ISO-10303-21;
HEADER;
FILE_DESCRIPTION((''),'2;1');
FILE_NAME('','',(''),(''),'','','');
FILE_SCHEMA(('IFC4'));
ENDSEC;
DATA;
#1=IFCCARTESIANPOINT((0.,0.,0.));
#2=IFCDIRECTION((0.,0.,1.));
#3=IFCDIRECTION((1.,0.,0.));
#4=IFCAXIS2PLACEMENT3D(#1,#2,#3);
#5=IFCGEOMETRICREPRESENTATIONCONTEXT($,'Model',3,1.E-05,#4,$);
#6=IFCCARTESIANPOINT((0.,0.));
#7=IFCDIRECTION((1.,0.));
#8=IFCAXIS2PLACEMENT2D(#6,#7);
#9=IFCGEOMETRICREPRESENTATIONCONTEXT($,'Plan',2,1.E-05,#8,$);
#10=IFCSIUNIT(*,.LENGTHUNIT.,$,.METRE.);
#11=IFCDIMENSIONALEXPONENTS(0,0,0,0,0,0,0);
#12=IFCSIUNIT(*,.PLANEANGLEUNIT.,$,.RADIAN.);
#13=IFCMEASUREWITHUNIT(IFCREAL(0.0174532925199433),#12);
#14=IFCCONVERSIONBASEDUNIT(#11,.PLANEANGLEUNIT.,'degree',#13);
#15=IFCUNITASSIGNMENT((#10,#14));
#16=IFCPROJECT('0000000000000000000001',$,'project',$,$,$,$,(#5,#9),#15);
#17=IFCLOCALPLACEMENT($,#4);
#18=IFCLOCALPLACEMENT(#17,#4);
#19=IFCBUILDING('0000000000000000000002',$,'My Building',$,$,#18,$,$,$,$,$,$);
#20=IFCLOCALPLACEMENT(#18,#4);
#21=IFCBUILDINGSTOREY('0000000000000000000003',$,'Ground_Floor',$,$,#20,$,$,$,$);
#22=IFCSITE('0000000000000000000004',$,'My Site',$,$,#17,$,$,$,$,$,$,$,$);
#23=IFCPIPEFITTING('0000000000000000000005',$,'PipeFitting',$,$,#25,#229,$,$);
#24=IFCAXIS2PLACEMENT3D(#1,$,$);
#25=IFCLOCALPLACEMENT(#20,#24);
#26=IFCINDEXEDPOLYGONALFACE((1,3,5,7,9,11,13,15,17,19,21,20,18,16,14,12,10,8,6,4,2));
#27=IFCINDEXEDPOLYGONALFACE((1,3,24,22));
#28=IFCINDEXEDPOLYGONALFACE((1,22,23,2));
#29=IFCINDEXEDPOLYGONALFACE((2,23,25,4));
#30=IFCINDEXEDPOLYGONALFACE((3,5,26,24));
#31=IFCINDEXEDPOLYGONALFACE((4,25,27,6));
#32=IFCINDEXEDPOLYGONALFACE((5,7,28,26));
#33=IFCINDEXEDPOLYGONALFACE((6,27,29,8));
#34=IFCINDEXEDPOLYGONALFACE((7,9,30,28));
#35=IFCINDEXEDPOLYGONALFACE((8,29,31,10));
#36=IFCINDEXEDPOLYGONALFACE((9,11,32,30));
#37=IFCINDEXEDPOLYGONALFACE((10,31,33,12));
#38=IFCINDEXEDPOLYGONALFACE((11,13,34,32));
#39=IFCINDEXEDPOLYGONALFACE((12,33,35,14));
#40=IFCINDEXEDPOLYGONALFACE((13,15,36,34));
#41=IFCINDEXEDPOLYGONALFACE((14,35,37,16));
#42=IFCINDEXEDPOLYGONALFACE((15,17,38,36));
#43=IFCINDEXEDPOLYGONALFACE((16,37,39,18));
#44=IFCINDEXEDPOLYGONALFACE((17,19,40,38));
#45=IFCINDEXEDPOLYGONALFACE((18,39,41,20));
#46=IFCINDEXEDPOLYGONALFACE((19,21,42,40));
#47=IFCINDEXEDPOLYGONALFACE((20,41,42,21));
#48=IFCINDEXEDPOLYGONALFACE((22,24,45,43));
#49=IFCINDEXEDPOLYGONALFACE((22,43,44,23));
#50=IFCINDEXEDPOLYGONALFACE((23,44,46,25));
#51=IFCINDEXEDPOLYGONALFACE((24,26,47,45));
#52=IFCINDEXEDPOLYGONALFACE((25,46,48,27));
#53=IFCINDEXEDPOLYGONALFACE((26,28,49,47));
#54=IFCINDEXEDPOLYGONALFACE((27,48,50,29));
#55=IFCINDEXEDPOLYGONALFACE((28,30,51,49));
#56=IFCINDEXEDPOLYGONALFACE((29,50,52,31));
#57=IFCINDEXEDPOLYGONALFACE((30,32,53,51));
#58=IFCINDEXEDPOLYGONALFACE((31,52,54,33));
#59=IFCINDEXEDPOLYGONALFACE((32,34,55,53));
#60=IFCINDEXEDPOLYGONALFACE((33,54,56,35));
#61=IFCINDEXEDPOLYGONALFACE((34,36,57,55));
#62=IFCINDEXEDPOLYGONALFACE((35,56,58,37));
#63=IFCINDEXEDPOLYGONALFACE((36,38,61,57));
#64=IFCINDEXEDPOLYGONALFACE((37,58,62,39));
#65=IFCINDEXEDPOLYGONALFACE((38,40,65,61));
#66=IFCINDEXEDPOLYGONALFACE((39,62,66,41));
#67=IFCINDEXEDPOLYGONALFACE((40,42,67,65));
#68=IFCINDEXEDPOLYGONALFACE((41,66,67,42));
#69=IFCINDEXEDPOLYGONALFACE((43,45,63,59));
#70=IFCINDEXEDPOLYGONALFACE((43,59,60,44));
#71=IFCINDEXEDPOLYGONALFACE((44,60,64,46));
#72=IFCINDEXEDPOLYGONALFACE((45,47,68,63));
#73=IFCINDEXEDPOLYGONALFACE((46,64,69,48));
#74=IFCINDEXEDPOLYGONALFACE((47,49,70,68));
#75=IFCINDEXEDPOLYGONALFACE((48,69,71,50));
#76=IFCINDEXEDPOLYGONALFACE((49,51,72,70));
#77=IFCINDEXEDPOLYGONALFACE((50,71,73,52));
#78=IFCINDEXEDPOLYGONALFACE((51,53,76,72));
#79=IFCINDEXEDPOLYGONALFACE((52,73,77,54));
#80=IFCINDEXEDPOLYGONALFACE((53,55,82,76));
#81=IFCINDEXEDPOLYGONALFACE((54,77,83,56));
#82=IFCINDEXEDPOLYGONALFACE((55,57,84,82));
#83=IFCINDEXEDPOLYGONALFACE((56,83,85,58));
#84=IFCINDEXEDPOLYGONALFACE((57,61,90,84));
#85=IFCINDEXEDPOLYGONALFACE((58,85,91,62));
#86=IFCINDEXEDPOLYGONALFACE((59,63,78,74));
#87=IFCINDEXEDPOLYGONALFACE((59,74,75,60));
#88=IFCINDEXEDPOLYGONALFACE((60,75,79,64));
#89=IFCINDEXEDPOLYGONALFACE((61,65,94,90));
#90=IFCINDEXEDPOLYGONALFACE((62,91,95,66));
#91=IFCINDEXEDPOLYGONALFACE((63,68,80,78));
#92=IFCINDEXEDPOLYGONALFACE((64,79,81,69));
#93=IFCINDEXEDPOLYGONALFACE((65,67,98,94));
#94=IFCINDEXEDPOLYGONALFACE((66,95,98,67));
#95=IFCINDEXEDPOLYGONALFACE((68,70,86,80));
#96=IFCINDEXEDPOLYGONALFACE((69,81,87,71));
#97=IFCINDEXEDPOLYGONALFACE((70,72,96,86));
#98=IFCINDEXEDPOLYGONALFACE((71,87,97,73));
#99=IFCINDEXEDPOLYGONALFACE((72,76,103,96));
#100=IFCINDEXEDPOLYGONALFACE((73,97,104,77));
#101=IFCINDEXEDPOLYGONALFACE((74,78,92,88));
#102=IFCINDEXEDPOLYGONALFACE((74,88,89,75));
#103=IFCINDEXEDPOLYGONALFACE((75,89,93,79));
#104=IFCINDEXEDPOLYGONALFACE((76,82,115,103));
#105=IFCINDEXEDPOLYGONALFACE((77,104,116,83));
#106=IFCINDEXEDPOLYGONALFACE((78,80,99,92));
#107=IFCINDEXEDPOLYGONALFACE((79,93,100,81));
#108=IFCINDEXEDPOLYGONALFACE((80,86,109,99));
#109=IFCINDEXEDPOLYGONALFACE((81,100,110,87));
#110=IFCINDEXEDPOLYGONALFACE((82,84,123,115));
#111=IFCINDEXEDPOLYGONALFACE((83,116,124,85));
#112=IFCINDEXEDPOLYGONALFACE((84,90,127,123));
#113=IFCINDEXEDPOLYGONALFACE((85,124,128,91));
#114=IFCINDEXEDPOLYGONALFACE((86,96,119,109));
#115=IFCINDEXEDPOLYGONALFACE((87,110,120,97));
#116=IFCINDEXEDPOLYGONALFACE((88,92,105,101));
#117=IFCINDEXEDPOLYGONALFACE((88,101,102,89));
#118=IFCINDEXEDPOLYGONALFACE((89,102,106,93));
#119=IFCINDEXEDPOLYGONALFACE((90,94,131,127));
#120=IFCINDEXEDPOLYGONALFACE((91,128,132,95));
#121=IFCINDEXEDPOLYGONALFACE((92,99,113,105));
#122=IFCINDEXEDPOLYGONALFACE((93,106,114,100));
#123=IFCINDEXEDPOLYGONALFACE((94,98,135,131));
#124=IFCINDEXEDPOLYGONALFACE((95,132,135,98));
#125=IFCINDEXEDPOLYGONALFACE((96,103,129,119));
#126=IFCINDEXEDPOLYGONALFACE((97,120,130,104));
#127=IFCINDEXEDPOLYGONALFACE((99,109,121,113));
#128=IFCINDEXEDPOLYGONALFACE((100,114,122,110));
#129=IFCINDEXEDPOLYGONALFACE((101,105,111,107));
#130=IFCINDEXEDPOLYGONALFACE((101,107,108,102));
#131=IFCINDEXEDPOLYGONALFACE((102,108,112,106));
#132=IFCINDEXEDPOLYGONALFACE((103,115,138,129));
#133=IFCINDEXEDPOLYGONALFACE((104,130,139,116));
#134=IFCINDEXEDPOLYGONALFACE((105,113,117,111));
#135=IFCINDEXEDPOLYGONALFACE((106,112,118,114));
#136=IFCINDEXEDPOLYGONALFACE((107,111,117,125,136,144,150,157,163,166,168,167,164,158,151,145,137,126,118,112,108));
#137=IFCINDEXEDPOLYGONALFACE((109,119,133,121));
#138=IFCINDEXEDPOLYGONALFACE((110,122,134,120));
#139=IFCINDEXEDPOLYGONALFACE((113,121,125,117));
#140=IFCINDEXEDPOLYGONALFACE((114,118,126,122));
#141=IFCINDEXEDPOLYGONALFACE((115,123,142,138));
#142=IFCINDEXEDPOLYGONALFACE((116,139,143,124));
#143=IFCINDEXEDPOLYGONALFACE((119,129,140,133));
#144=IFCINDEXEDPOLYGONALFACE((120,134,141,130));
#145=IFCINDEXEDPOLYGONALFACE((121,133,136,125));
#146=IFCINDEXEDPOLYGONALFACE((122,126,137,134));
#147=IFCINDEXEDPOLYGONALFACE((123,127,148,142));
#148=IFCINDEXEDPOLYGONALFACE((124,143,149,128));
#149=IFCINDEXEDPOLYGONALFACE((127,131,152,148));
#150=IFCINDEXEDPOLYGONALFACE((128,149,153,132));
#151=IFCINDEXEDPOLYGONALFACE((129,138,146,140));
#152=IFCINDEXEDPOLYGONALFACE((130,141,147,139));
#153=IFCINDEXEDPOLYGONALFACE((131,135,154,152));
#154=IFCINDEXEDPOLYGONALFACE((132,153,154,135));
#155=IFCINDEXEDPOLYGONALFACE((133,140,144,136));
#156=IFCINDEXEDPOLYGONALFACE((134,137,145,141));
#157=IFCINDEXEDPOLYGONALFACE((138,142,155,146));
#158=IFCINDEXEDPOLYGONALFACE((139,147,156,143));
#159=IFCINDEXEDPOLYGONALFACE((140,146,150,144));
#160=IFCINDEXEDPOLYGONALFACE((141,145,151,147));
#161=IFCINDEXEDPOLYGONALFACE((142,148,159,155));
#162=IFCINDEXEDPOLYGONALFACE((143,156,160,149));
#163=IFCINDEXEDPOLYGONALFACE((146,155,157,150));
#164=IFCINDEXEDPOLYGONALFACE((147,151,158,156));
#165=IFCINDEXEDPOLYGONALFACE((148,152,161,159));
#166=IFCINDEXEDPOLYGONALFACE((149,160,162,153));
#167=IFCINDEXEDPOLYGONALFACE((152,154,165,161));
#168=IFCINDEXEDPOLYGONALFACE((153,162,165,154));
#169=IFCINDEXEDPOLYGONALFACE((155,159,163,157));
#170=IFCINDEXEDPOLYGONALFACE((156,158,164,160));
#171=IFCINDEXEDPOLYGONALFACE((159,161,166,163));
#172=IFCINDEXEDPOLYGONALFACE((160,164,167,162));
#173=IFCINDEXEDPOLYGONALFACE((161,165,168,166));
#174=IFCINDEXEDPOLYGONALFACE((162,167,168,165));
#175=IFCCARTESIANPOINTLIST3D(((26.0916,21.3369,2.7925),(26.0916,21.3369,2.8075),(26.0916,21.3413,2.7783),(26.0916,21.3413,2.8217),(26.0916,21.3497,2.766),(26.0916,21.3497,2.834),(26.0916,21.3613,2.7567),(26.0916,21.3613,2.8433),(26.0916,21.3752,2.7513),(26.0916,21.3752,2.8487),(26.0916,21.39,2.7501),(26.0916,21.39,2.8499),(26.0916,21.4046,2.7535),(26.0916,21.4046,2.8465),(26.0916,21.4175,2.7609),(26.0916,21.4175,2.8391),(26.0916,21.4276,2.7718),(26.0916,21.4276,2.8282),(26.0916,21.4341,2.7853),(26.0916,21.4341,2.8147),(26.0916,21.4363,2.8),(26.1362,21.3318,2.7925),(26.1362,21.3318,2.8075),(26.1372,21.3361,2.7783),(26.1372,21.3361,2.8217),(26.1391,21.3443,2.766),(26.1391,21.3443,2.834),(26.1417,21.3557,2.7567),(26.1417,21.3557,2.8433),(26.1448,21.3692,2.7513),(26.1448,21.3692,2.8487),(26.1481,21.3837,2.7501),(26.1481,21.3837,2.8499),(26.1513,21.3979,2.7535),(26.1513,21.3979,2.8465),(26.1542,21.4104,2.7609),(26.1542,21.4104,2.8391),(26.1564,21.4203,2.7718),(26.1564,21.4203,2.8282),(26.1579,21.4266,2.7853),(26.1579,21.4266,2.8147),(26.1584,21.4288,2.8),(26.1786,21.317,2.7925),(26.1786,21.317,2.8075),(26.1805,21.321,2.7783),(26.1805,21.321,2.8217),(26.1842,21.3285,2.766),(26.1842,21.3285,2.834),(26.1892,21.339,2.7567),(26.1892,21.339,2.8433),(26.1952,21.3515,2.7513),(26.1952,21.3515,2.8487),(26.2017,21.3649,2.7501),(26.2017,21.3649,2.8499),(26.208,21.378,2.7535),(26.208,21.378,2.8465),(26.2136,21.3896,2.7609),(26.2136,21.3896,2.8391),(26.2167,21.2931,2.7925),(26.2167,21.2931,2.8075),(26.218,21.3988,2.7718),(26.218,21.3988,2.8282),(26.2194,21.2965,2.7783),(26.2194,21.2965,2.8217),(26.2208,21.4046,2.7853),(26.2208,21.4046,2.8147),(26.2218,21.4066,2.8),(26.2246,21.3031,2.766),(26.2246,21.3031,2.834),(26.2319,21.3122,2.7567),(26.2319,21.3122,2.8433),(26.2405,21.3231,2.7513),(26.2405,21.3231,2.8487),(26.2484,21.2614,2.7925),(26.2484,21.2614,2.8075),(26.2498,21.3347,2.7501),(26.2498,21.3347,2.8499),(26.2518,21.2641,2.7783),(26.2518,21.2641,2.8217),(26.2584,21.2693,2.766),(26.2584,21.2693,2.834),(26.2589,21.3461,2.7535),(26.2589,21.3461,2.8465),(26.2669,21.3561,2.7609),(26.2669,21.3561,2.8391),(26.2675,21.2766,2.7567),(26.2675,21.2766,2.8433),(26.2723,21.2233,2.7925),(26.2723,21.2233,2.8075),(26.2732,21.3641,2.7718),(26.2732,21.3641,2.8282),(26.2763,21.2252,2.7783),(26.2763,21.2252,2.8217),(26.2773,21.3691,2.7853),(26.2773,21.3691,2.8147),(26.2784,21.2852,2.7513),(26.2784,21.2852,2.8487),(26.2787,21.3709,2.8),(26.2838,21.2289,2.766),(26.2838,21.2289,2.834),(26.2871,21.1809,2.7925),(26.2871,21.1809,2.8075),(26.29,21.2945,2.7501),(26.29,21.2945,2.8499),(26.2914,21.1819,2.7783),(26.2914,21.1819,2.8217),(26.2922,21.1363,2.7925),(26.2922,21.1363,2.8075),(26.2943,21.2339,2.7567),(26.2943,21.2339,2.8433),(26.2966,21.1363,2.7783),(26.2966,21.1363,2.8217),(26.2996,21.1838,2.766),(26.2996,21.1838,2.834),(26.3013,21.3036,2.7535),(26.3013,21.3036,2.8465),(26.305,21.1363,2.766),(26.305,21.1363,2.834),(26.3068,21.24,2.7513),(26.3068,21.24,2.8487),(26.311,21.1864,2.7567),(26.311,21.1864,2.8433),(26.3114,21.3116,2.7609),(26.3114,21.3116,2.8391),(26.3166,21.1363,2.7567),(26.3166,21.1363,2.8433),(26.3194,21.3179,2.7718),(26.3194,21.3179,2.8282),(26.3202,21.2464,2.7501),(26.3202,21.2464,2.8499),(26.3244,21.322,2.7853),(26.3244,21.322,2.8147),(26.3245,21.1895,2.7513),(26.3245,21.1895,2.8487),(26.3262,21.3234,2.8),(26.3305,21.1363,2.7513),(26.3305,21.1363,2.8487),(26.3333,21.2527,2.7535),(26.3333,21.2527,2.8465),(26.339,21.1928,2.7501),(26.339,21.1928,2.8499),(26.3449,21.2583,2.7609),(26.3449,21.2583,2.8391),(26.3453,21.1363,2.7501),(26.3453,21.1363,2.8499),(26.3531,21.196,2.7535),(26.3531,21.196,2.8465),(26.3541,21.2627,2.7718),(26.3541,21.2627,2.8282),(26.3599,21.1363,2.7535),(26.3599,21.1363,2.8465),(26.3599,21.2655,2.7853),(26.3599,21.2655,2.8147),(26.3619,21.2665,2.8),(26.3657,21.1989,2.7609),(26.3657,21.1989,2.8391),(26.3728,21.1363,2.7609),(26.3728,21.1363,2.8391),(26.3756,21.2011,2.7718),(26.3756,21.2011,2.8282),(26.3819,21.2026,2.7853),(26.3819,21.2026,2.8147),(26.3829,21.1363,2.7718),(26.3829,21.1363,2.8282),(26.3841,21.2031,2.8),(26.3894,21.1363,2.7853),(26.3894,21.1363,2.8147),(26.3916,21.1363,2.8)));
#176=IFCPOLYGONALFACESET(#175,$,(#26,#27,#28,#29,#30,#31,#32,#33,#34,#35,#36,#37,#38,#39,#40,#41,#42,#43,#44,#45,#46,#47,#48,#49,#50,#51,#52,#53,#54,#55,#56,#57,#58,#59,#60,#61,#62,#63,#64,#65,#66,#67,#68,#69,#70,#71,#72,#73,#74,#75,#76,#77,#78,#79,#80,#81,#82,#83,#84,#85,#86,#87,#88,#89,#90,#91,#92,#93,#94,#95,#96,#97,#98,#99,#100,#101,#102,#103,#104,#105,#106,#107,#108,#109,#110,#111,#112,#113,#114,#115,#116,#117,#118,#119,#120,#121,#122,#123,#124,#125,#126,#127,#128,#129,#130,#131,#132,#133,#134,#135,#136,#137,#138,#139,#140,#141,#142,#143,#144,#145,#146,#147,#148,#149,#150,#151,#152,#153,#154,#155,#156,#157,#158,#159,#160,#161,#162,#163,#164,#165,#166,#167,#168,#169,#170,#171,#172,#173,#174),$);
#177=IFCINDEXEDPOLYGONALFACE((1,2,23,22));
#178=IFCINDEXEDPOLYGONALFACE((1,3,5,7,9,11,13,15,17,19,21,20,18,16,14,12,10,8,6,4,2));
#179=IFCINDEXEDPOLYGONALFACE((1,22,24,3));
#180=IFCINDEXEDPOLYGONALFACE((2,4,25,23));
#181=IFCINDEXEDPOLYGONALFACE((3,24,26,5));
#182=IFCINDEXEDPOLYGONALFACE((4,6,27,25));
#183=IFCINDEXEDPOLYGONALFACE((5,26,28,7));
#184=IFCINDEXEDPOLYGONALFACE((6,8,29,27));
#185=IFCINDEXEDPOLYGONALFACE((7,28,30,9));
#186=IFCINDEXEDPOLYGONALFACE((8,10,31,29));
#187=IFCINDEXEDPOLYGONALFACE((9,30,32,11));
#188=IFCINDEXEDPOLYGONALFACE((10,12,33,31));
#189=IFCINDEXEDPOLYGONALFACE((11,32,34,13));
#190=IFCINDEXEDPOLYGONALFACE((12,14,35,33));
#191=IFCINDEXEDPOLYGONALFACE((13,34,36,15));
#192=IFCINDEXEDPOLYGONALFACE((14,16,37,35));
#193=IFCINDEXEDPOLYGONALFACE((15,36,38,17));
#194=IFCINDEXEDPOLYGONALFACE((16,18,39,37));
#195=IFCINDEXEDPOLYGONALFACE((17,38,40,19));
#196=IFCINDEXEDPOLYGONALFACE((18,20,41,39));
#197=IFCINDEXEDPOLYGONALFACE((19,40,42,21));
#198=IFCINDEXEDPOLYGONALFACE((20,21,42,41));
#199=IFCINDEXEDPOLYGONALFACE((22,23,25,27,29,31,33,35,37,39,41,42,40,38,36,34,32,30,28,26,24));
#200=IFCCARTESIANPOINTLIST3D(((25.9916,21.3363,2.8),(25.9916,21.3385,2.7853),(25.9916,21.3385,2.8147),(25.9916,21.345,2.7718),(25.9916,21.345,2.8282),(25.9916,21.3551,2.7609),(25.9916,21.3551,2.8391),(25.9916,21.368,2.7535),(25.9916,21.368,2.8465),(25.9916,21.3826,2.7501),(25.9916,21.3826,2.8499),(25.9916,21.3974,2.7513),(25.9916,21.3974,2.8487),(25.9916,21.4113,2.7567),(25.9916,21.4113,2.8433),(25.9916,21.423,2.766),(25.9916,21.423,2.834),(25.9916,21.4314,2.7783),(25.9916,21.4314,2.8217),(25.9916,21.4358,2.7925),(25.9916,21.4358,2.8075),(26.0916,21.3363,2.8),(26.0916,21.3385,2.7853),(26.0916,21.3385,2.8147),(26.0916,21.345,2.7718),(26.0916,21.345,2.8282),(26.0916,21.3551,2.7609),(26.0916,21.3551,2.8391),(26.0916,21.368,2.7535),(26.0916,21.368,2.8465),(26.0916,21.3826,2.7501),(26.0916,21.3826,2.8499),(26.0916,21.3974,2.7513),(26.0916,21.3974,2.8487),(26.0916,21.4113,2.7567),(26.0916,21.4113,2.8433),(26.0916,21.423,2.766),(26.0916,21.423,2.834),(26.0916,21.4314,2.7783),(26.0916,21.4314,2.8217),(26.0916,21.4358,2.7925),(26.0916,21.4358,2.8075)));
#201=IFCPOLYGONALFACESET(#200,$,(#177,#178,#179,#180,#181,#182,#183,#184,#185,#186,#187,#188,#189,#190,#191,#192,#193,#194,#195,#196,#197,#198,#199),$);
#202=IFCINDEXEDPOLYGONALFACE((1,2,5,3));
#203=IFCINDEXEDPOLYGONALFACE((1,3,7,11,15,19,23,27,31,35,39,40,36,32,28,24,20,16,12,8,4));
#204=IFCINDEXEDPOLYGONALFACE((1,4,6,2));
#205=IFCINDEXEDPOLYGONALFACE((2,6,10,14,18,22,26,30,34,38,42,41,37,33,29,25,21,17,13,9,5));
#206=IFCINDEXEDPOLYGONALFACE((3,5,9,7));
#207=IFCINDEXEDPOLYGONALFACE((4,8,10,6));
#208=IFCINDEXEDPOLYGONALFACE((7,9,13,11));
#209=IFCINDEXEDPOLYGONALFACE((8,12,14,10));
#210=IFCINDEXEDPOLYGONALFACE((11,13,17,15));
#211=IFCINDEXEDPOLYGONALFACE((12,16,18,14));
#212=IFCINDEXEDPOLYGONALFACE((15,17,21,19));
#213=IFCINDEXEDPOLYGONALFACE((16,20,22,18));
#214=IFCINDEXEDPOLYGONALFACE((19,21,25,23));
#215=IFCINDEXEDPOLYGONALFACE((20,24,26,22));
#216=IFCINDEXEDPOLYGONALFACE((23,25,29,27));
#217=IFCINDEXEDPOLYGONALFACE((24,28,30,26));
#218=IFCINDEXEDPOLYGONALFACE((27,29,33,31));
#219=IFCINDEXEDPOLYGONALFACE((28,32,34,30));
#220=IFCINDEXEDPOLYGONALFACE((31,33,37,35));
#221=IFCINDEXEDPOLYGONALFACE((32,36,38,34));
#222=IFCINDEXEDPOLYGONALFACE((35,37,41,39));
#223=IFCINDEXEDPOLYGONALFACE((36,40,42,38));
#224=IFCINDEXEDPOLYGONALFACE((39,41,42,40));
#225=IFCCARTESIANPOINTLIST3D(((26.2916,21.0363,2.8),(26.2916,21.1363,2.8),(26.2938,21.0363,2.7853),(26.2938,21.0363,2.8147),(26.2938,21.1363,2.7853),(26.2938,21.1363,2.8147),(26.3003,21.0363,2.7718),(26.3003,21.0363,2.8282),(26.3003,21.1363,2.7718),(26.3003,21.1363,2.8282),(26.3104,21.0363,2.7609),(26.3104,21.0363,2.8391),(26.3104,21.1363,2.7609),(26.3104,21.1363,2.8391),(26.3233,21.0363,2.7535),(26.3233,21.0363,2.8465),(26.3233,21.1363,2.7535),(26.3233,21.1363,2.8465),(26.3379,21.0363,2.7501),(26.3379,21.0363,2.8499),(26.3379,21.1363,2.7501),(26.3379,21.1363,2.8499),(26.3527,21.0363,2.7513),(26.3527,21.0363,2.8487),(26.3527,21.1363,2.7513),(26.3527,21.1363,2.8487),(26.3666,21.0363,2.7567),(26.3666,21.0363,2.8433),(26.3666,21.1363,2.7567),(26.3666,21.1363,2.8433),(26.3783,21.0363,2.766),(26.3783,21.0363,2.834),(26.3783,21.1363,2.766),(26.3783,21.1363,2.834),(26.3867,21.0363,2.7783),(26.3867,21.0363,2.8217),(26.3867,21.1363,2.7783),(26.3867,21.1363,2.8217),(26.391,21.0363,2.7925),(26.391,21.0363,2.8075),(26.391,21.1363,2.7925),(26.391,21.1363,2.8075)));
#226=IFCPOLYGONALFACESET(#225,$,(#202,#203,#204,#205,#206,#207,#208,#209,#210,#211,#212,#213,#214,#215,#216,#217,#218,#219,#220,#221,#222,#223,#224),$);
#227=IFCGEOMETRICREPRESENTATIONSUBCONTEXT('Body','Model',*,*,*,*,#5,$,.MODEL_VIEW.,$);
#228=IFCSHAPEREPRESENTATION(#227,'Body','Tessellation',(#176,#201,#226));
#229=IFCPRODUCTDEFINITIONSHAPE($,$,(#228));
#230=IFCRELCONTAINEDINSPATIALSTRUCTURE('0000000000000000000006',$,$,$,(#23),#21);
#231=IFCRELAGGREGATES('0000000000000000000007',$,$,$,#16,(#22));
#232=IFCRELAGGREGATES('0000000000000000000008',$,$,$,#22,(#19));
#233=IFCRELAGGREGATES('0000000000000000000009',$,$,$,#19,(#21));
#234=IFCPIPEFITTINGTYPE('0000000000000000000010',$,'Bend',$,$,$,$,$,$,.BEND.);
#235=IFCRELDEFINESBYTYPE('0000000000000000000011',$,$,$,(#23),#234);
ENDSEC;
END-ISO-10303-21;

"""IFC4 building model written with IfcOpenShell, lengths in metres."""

from ifc_helpers import new_model, entity, si_unit, converted_unit, frame, origin_with_axes, origin_2d_with_axis, place, context, subcontext, project, spatial, circle, extrude, source, transform, mapped, type_object, type_shapes, element, save


model = new_model("IFC4")

# Units and contexts
model_context = context("Model", 3, precision=1e-05, world=origin_with_axes())
plan_context = context("Plan", 2, precision=1e-05, world=origin_2d_with_axis())
body_context = subcontext(model_context, "Body", "Model", "MODEL_VIEW")
ifc_project = project(units=[si_unit("LENGTHUNIT", "METRE"), converted_unit("PLANEANGLEUNIT", "degree", entity("IfcReal", 0.0174532925199433), si_unit("PLANEANGLEUNIT", "RADIAN"), dimensions=[0, 0, 0, 0, 0, 0, 0])], contexts=[model_context, plan_context])

# Site, building, storey
site_placement = place(None, origin_with_axes())
site = spatial("IfcSite", under=ifc_project, at=site_placement, Name="My Site")
building_placement = place(site_placement, origin_with_axes())
building = spatial("IfcBuilding", under=site, at=building_placement, Name="My Building")
storey_placement = place(building_placement, origin_with_axes())
storey = spatial("IfcBuildingStorey", under=building, at=storey_placement, Name="Ground_Floor")

# Pipe fitting
pipe_fitting_type = type_object("IfcPipeFittingType", Name="Bend", PredefinedType="BEND")
shared_shape = source(origin_with_axes(), body_context, "Body", "SolidModel", [
    entity("IfcSweptDiskSolid", entity("IfcIndexedPolyCurve", entity("IfcCartesianPointList3D", [[0.0, 0.0, -0.1], [0.0732, 0.0, -0.2768], [0.25, 0.0, -0.35]]), [entity("IfcArcIndex", [1, 2, 3])]), 0.05),
    extrude(circle(Radius=0.05), origin_with_axes(), (0.0, 0.0, -1.0), 0.1),
    extrude(circle(Radius=0.05), frame((0.25, 0.0, -0.35), z_axis=(1.0, 0.0, 0.0), x_axis=(0.0, 0.0, 1.0)), (0.0, 0.0, 1.0), 0.1),
])
type_shapes(pipe_fitting_type, [shared_shape])
for number, where, z_axis, x_axis, name in (
    (1, (25.9916, 21.3863, 2.8), (-1.0, 0.0, 0.0), (0.0, -1.0, 0.0), "PipeFitting"),
):
    element("IfcPipeFitting", number, at=place(storey_placement, frame(where, z_axis=z_axis, x_axis=x_axis)), inside=storey, type_object=pipe_fitting_type, Name=name, context=body_context, shape_type="MappedRepresentation", body=[
        mapped(shared_shape, transform((0.0, 0.0, 0.0), x_axis=(1.0, 0.0, 0.0), y_axis=(0.0, 1.0, 0.0), z_axis=(0.0, 0.0, 1.0), scale=1.0)),
    ])

save(model, "model.ifc")
